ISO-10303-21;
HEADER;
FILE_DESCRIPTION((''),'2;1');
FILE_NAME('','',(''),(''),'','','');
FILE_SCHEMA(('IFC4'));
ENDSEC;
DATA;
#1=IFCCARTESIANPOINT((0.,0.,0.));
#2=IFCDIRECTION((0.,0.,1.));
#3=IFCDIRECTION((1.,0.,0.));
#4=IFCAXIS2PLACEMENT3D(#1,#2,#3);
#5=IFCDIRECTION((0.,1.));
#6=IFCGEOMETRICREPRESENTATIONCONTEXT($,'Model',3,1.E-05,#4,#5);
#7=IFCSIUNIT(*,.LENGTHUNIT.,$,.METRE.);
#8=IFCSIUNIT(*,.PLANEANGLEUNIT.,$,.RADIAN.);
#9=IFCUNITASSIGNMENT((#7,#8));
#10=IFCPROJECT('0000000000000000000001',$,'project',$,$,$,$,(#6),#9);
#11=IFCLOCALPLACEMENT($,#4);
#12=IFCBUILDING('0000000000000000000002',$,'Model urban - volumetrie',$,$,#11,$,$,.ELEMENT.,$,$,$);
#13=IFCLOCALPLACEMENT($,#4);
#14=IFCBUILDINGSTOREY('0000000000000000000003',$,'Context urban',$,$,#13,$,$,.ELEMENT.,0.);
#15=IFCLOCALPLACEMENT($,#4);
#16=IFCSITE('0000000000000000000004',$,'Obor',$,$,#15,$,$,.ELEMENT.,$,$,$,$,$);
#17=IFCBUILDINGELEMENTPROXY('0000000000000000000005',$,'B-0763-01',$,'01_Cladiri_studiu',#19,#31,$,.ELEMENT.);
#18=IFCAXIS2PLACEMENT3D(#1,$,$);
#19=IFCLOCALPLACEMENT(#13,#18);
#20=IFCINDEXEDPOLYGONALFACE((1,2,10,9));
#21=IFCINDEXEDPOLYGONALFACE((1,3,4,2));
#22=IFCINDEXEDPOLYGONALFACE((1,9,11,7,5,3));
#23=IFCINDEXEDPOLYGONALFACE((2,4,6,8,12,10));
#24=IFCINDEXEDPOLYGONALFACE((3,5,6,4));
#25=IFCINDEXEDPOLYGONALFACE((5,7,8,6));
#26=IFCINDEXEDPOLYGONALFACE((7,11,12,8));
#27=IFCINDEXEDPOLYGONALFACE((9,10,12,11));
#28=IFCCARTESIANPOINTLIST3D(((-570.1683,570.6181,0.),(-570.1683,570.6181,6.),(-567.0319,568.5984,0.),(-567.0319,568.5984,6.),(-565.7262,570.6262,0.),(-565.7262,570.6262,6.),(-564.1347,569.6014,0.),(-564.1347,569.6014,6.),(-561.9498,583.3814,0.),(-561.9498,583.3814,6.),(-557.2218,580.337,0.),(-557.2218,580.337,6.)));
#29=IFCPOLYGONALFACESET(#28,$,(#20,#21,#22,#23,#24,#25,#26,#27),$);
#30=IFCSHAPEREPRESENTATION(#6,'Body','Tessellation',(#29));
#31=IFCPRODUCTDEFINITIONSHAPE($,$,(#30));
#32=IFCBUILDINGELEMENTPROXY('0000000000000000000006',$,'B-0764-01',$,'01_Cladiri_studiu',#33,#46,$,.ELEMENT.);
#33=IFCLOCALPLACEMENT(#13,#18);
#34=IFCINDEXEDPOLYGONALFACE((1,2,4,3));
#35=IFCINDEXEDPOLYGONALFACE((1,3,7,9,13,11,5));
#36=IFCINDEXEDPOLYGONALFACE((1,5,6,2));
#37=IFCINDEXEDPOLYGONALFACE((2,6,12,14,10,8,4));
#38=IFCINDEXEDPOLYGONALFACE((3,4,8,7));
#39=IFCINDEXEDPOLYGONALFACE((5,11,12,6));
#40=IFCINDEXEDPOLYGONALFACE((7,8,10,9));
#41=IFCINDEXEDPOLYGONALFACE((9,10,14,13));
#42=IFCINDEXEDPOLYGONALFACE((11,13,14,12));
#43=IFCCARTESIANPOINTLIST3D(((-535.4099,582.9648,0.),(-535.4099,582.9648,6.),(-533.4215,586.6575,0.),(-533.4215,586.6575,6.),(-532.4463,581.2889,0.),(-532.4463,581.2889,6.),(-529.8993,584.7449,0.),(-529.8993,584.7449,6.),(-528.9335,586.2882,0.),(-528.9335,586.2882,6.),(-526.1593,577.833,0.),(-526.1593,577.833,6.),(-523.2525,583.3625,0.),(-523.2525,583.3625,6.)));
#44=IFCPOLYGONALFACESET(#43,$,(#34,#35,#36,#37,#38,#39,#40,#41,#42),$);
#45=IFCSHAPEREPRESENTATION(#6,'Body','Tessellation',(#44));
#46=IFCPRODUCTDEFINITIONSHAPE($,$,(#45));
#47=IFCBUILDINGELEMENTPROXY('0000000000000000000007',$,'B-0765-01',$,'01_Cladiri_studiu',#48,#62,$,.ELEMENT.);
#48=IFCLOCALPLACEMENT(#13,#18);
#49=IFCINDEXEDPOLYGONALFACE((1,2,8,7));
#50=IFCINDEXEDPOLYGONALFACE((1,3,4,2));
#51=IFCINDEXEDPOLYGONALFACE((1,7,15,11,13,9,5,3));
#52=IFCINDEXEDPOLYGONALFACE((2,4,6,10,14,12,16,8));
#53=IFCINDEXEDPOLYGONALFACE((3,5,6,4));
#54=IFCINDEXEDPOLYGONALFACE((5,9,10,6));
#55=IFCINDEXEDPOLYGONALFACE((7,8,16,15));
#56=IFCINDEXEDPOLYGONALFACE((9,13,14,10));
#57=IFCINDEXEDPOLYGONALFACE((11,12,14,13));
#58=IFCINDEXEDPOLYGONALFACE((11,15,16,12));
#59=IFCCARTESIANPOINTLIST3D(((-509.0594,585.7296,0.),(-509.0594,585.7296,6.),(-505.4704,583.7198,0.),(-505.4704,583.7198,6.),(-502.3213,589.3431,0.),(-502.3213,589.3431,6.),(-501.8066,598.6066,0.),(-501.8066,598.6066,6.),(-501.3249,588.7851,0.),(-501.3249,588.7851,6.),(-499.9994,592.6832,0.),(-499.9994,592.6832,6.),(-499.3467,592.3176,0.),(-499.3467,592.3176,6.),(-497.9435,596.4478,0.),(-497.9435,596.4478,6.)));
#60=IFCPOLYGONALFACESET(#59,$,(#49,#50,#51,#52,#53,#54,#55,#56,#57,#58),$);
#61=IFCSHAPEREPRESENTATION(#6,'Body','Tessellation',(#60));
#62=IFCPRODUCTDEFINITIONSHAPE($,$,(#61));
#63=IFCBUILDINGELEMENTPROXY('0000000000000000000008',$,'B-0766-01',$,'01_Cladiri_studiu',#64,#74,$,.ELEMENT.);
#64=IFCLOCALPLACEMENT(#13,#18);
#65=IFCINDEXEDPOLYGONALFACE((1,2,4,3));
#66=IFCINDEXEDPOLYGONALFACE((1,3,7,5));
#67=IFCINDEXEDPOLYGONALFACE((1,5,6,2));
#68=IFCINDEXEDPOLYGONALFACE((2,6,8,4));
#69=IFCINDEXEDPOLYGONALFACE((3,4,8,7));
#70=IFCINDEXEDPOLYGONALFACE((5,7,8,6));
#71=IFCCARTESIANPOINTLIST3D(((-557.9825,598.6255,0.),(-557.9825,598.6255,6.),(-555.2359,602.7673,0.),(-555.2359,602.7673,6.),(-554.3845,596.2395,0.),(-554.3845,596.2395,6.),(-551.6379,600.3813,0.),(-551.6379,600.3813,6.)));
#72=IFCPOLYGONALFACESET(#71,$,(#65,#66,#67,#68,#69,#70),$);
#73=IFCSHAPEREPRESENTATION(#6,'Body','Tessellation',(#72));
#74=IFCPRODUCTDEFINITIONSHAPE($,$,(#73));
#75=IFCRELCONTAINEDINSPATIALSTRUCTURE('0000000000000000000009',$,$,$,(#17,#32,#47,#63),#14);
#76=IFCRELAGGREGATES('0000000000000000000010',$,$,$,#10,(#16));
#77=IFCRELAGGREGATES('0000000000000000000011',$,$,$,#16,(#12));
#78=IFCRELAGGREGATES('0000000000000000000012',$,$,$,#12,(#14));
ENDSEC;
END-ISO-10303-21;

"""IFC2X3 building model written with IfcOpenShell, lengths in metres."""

from ifc_helpers import new_model, si_unit, direction, origin_with_axes, place, context, project, spatial, polyline, outline, extrude, element, save


model = new_model("IFC2X3")

# Units and contexts
model_context = context("Model", 3, precision=1e-05, world=origin_with_axes(), true_north=direction((0.0, 1.0)))
ifc_project = project(units=[si_unit("LENGTHUNIT", "METRE"), si_unit("PLANEANGLEUNIT", "RADIAN")], contexts=[model_context])

# Site, building, storey
site_placement = place(None, origin_with_axes())
site = spatial("IfcSite", under=ifc_project, at=site_placement, Name="Obor", CompositionType="ELEMENT")
building_placement = place(None, origin_with_axes())
building = spatial("IfcBuilding", under=site, at=building_placement, Name="Model urban - volumetrie", CompositionType="ELEMENT")
storey_placement = place(None, origin_with_axes())
storey = spatial("IfcBuildingStorey", under=building, at=storey_placement, Name="Context urban", CompositionType="ELEMENT", Elevation=0.0)

# Building element proxies
proxy_1_placement = place(None, origin_with_axes())
element("IfcBuildingElementProxy", 1, at=proxy_1_placement, inside=storey, Name="B-0763-01", ObjectType="01_Cladiri_studiu", CompositionType="ELEMENT", context=model_context, shape_type="SweptSolid", body=[
    extrude(outline(polyline([(-557.2218, 580.337), (-561.9498, 583.3814), (-570.1683, 570.6181), (-567.0319, 568.5984), (-565.7262, 570.6262), (-564.1347, 569.6014), (-557.2218, 580.337)])), origin_with_axes(), (0.0, 0.0, 1.0), 6.0),
])
proxy_2_placement = place(None, origin_with_axes())
element("IfcBuildingElementProxy", 2, at=proxy_2_placement, inside=storey, Name="B-0764-01", ObjectType="01_Cladiri_studiu", CompositionType="ELEMENT", context=model_context, shape_type="SweptSolid", body=[
    extrude(outline(polyline([(-535.4099, 582.9648), (-532.4463, 581.2889), (-526.1593, 577.833), (-523.2525, 583.3625), (-528.9335, 586.2882), (-529.8993, 584.7449), (-533.4215, 586.6575), (-535.4099, 582.9648)])), origin_with_axes(), (0.0, 0.0, 1.0), 6.0),
])
proxy_3_placement = place(None, origin_with_axes())
element("IfcBuildingElementProxy", 3, at=proxy_3_placement, inside=storey, Name="B-0765-01", ObjectType="01_Cladiri_studiu", CompositionType="ELEMENT", context=model_context, shape_type="SweptSolid", body=[
    extrude(outline(polyline([(-505.4704, 583.7198), (-502.3213, 589.3431), (-501.3249, 588.7851), (-499.3467, 592.3176), (-499.9994, 592.6832), (-497.9435, 596.4478), (-501.8066, 598.6066), (-509.0594, 585.7296), (-505.4704, 583.7198)])), origin_with_axes(), (0.0, 0.0, 1.0), 6.0),
])
proxy_4_placement = place(None, origin_with_axes())
element("IfcBuildingElementProxy", 4, at=proxy_4_placement, inside=storey, Name="B-0766-01", ObjectType="01_Cladiri_studiu", CompositionType="ELEMENT", context=model_context, shape_type="SweptSolid", body=[
    extrude(outline(polyline([(-551.6379, 600.3813), (-555.2359, 602.7673), (-557.9825, 598.6255), (-554.3845, 596.2395), (-551.6379, 600.3813)])), origin_with_axes(), (0.0, 0.0, 1.0), 6.0),
])

save(model, "model.ifc")
